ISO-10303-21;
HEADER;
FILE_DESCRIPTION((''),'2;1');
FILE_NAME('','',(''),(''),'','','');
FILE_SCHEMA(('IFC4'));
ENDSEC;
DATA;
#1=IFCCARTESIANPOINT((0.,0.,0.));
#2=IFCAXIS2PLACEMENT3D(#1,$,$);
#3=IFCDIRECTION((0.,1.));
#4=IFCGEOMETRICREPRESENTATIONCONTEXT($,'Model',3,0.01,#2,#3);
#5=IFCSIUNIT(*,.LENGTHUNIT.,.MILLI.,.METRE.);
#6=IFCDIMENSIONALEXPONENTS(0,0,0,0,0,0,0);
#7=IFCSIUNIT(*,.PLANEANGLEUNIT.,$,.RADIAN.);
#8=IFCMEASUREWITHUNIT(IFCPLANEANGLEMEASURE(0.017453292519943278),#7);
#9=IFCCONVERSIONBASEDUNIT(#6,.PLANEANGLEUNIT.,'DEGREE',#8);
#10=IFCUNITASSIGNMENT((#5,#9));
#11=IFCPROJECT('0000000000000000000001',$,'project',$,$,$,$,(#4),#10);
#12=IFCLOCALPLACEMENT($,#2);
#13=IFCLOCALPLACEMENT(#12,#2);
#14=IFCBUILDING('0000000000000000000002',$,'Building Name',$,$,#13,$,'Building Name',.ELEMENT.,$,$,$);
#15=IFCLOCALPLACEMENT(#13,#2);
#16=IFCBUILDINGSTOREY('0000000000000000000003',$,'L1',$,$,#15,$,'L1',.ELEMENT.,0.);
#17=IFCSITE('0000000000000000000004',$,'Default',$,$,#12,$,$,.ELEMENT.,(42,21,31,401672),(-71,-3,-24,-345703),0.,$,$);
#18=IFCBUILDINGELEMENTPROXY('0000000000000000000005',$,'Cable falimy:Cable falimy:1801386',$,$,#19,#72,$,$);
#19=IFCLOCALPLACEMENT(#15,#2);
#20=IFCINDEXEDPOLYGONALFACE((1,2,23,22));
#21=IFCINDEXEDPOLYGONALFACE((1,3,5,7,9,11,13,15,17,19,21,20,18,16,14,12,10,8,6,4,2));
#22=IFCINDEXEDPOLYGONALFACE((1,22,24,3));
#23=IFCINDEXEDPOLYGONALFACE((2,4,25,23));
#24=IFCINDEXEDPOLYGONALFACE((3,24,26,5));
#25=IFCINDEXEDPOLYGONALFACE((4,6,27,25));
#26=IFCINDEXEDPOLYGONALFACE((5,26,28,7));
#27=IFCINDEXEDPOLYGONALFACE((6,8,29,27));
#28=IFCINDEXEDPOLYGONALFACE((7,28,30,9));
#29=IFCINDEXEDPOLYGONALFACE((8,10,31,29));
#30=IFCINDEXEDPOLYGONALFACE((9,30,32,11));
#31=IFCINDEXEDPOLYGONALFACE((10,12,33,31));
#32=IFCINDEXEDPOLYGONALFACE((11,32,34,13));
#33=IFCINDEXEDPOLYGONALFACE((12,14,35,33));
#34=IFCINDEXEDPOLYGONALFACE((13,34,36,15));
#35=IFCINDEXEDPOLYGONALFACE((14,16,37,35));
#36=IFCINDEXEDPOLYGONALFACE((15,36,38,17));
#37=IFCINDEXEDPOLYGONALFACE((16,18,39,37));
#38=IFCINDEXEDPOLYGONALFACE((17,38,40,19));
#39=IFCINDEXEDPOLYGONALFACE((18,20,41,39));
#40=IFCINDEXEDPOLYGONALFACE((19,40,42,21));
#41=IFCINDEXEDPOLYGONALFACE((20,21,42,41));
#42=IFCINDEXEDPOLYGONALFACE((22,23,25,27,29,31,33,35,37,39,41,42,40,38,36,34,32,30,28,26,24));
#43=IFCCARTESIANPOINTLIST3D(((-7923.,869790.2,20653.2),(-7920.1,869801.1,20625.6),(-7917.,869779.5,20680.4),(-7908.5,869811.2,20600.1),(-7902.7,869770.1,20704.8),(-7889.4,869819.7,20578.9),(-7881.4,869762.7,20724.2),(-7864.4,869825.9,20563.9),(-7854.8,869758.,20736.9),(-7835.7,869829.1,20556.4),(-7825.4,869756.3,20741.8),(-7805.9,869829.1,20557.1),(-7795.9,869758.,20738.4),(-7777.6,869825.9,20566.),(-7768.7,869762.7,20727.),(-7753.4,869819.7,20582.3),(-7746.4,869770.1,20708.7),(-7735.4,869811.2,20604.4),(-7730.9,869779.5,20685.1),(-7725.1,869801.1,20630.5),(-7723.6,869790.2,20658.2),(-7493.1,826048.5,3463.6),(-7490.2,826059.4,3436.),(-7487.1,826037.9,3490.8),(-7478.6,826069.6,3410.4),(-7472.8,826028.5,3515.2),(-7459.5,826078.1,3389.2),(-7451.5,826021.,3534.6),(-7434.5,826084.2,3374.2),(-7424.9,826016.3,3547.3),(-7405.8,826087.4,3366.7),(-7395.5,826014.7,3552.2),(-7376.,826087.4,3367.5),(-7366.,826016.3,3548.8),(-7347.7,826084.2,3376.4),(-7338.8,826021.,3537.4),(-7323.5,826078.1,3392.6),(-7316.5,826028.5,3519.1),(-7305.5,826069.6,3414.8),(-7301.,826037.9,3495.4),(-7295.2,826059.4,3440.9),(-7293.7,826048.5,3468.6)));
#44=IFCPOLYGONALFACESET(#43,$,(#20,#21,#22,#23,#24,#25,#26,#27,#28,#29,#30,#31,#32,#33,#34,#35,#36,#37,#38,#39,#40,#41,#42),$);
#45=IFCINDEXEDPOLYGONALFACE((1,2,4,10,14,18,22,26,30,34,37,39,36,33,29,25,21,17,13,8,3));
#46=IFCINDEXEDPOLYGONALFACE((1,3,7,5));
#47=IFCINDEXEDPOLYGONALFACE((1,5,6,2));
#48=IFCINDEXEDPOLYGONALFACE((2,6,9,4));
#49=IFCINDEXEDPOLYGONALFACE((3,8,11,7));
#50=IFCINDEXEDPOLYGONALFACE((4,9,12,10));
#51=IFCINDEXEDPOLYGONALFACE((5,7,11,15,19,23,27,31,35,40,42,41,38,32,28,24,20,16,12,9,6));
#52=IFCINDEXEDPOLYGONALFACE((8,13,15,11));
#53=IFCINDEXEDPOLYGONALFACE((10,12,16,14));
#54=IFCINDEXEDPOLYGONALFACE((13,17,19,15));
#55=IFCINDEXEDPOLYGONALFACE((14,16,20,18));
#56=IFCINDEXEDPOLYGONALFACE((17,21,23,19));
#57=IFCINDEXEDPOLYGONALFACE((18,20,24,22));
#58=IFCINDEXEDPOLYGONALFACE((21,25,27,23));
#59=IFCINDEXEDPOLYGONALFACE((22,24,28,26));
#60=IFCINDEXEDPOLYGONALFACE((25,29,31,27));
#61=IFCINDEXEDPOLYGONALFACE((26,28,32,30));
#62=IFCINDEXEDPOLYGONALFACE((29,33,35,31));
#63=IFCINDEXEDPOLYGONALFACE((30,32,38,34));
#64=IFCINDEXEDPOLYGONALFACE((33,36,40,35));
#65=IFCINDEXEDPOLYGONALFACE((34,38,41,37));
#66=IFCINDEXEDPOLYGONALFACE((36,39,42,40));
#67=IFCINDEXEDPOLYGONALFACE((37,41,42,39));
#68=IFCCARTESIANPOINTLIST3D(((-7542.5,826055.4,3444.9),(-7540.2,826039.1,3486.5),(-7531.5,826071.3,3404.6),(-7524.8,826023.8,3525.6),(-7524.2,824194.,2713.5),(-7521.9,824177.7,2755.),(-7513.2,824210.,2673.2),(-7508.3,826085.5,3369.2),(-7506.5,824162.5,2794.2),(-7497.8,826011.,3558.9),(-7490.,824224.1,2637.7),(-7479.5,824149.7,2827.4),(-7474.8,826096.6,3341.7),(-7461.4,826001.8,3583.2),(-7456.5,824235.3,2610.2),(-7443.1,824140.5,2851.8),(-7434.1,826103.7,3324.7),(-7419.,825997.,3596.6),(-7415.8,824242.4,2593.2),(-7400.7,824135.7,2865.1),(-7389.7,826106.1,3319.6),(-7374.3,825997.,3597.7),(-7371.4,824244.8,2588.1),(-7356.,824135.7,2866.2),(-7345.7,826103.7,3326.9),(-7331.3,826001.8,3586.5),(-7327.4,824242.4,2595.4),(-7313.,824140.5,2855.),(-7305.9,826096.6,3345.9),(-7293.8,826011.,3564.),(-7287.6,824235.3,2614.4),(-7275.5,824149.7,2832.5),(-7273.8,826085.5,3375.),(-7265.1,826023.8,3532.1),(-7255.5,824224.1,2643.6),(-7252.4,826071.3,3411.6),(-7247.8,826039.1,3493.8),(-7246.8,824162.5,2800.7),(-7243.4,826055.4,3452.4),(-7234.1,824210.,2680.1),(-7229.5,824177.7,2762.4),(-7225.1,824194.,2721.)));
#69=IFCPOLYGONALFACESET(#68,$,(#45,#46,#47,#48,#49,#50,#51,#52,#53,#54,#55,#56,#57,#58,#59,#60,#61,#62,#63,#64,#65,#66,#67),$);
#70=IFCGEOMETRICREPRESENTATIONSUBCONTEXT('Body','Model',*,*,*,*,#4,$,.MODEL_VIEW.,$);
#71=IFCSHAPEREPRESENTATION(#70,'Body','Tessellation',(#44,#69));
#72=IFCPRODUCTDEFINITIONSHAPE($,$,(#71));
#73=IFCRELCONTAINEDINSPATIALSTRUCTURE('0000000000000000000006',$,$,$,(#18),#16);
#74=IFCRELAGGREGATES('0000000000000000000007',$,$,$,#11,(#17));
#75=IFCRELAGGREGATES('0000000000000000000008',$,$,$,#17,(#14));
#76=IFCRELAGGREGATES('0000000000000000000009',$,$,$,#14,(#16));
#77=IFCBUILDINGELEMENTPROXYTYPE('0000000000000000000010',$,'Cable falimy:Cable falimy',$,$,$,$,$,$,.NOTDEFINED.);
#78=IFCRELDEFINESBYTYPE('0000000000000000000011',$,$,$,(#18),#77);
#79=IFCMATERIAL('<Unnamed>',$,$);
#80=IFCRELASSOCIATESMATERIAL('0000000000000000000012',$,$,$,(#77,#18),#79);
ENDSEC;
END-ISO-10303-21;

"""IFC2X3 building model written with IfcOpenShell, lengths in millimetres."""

from ifc_helpers import new_model, entity, si_unit, converted_unit, direction, frame, frame_2d, origin, place, context, subcontext, project, spatial, circle, extrude, source, transform, mapped, material, type_object, type_shapes, element, save


model = new_model("IFC2X3")

# Units and contexts
model_context = context("Model", 3, precision=0.01, world=origin(), true_north=direction((0.0, 1.0)))
body_context = subcontext(model_context, "Body", "Model", "MODEL_VIEW")
ifc_project = project(units=[si_unit("LENGTHUNIT", "METRE", prefix="MILLI"), converted_unit("PLANEANGLEUNIT", "DEGREE", entity("IfcPlaneAngleMeasure", 0.017453292519943278), si_unit("PLANEANGLEUNIT", "RADIAN"), dimensions=[0, 0, 0, 0, 0, 0, 0])], contexts=[model_context])

# Site, building, storey
site_placement = place(None, origin())
site = spatial("IfcSite", under=ifc_project, at=site_placement, Name="Default", CompositionType="ELEMENT", RefLatitude=(42, 21, 31, 401672), RefLongitude=(-71, -3, -24, -345703), RefElevation=0.0)
building_placement = place(site_placement, origin())
building = spatial("IfcBuilding", under=site, at=building_placement, Name="Building Name", LongName="Building Name", CompositionType="ELEMENT")
storey_placement = place(building_placement, origin())
storey = spatial("IfcBuildingStorey", under=building, at=storey_placement, Name="L1", LongName="L1", CompositionType="ELEMENT", Elevation=0.0)

# Shared definitions
ifc_material = material(Name="<Unnamed>")

# Building element proxy
building_element_proxy_type_1 = type_object("IfcBuildingElementProxyType", Name="Cable falimy:Cable falimy", PredefinedType="NOTDEFINED", material=ifc_material)
shared_shape_1 = source(origin(), body_context, "Body", "SweptSolid", [
    extrude(circle(Radius=100.0, at=frame_2d((0.0, 0.0), x_axis=(1.0, 0.0))), frame((0.0, 0.0, 0.0), z_axis=(0.930673, 0.0, 0.365852), x_axis=(-0.365852, 0.0, 0.930673)), (0.0, 0.0, 1.0), 47000.0),
    extrude(circle(Radius=150.0, at=frame_2d((0.0, 0.0), x_axis=(1.0, 0.0))), frame((-1861.3, 0.0, -731.7), z_axis=(0.930673, 0.0, 0.365852), x_axis=(0.365852, 0.0, -0.930673)), (0.0, 0.0, 1.0), 2000.0),
])
type_shapes(building_element_proxy_type_1, [shared_shape_1])
proxy_1_placement = place(storey_placement, frame((-7393.2, 826051.3, 3459.1), z_axis=(-0.025001, 0.0, 0.999687), x_axis=(0.0, 1.0, 0.0)))
element("IfcBuildingElementProxy", 1, at=proxy_1_placement, inside=storey, type_object=building_element_proxy_type_1, material=ifc_material, Name="Cable falimy:Cable falimy:1801386", context=body_context, shape_type="MappedRepresentation", body=[
    mapped(shared_shape_1, transform((0.0, 0.0, 0.0), scale=1.0)),
])

save(model, "model.ifc")
